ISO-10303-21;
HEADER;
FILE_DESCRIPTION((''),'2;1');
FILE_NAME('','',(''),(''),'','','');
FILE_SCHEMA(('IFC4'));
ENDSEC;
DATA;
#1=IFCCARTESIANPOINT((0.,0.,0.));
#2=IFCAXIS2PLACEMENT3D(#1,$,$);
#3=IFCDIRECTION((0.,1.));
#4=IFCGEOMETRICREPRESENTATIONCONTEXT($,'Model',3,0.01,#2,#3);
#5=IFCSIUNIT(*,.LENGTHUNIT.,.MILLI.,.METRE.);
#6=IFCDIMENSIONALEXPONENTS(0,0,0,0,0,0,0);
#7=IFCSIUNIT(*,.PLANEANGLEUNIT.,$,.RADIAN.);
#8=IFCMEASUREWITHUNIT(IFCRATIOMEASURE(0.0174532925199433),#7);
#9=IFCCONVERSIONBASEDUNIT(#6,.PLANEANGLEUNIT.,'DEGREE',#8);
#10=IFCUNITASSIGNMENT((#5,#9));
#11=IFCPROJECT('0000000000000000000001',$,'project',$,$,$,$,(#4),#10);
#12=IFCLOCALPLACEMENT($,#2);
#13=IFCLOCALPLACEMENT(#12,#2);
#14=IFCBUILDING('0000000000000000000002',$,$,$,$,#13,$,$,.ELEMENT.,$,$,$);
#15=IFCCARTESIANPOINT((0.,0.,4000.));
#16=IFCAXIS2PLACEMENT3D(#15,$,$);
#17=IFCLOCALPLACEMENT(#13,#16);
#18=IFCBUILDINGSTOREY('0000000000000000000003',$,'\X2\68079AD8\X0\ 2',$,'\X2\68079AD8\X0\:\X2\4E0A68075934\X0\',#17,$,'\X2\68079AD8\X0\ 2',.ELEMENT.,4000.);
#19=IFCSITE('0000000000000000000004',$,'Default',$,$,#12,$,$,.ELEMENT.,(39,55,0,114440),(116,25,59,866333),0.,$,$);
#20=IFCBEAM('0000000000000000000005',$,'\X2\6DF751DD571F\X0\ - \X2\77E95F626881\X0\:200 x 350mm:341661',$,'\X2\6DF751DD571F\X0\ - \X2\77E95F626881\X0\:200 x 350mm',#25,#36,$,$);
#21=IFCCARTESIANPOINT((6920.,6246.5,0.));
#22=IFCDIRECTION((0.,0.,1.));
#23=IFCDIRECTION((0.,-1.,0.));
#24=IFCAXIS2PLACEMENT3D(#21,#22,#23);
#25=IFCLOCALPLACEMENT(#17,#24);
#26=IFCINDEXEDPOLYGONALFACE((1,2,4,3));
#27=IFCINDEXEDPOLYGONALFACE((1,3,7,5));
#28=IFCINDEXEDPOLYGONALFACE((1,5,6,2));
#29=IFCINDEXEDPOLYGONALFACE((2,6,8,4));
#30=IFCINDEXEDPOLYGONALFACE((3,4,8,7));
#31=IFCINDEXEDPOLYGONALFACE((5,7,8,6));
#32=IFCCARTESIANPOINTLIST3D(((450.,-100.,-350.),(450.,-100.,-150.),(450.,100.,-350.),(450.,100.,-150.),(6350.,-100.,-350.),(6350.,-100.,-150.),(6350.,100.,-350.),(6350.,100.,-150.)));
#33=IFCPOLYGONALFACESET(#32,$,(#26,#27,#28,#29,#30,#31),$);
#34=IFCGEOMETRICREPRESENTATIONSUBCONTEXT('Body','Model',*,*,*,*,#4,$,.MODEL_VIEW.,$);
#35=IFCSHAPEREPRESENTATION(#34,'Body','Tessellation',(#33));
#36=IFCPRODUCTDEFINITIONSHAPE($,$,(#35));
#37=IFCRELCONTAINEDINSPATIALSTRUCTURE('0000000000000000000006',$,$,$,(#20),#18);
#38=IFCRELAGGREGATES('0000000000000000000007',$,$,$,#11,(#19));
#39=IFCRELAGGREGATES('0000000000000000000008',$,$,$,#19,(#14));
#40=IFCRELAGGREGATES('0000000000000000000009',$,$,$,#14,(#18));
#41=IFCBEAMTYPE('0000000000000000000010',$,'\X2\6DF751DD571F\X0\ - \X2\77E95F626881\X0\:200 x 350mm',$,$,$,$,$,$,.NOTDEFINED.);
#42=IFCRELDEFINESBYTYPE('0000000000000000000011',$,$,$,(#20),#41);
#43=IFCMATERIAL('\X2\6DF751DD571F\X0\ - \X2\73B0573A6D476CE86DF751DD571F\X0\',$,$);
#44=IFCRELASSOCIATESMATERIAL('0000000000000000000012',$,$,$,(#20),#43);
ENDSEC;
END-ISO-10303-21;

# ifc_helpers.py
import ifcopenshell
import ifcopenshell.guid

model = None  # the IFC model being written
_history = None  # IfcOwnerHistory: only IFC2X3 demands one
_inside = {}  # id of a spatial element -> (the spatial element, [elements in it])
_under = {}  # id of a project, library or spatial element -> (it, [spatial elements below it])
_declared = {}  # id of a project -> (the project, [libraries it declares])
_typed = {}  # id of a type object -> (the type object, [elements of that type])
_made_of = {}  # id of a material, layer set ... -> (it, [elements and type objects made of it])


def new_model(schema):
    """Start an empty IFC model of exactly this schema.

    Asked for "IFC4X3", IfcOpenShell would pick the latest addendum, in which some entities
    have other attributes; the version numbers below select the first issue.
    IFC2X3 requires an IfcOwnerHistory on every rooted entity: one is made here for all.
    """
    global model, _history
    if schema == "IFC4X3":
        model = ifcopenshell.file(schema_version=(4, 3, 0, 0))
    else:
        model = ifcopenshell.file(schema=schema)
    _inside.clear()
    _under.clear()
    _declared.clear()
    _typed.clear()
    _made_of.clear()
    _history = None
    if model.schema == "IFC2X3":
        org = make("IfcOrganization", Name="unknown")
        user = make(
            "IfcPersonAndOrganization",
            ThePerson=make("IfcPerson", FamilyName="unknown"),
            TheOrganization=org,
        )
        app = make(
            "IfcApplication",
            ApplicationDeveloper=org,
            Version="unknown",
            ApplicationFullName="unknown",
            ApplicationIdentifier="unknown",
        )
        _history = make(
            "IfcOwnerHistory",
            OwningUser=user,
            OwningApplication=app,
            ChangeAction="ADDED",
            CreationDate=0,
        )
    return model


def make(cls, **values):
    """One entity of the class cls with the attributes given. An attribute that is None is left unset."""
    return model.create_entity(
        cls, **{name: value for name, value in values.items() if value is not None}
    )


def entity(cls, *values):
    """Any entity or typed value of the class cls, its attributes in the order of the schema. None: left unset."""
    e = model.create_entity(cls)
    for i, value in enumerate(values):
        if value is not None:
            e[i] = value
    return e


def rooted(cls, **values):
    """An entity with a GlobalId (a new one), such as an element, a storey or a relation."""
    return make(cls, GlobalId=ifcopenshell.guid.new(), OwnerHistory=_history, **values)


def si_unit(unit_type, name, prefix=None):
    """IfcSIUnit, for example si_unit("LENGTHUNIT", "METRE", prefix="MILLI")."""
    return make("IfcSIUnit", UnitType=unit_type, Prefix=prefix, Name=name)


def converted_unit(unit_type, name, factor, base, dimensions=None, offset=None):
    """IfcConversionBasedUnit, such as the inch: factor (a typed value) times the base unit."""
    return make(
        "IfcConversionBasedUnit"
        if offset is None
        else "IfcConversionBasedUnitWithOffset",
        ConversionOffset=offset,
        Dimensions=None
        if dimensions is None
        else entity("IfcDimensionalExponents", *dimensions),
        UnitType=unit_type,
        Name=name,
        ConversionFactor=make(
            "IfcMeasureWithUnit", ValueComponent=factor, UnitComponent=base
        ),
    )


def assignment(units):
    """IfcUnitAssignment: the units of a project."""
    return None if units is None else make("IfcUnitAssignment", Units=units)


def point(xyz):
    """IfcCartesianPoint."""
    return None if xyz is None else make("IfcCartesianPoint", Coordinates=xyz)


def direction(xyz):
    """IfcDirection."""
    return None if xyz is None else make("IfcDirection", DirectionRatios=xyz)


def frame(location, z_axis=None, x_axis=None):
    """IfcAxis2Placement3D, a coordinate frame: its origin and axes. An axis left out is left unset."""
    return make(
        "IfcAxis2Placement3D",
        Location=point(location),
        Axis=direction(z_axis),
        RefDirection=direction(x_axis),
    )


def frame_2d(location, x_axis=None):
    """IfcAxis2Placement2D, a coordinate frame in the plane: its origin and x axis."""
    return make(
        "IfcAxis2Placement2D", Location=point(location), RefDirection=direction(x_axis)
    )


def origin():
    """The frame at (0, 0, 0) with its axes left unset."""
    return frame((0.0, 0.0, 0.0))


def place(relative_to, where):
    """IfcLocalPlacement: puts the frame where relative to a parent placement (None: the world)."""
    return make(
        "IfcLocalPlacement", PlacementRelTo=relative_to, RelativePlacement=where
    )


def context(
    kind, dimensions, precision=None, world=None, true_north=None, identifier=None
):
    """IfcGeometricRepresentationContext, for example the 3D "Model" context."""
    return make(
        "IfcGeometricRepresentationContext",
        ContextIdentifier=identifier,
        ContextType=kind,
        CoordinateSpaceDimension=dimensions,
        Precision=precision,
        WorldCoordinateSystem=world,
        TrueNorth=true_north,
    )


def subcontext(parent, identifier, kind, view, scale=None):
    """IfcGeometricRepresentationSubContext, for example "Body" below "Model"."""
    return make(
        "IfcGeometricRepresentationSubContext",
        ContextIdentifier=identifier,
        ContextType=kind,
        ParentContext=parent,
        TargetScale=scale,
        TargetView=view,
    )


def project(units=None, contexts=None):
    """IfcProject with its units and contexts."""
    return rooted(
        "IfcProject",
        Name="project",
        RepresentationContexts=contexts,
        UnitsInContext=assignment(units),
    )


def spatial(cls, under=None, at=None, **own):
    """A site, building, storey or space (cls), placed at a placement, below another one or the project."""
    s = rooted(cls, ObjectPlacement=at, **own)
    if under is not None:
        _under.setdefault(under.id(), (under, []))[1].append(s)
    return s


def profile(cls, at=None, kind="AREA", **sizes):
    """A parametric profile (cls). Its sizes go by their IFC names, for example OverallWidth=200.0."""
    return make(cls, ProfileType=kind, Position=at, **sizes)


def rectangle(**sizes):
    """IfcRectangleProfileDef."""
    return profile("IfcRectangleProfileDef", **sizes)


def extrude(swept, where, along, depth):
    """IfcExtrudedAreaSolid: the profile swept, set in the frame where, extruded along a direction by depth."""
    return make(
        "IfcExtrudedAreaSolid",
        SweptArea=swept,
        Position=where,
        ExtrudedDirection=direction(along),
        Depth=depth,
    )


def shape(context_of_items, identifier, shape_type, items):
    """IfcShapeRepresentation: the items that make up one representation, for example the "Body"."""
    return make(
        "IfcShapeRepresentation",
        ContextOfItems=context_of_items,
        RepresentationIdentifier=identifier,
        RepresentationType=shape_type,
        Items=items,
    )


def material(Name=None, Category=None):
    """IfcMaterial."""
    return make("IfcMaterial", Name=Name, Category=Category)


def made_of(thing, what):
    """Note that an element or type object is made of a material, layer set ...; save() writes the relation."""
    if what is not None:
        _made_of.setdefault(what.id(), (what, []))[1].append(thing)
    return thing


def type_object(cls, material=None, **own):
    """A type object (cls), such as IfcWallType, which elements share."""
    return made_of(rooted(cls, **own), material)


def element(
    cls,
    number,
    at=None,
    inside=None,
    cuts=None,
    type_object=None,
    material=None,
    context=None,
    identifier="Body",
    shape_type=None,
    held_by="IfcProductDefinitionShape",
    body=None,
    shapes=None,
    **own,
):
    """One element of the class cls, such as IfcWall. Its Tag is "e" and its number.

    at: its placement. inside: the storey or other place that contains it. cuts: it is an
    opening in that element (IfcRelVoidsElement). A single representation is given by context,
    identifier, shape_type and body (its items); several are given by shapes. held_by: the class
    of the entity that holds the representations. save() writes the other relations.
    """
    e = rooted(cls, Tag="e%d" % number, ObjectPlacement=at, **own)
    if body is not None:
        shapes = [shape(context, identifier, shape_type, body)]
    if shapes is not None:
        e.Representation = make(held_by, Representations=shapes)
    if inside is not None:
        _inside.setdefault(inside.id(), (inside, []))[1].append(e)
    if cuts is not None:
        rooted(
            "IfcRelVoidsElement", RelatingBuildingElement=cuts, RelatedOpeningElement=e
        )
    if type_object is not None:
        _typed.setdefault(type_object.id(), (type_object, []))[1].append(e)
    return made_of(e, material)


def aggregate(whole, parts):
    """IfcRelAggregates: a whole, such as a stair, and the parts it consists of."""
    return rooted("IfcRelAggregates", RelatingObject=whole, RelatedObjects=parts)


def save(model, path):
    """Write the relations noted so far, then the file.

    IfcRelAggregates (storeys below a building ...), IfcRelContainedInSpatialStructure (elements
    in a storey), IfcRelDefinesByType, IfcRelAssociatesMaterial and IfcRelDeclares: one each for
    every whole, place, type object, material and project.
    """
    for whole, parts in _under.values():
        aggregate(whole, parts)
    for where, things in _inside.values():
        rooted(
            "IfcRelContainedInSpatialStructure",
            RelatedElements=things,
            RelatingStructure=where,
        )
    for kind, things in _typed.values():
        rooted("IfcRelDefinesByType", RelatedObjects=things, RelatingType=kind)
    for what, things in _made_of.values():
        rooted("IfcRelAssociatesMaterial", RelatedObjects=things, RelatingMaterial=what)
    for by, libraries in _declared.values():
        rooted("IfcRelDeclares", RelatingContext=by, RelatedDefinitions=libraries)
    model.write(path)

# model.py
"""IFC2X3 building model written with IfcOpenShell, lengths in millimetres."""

from ifc_helpers import new_model, entity, si_unit, converted_unit, direction, frame, frame_2d, origin, place, context, subcontext, project, spatial, rectangle, extrude, material, type_object, element, save


model = new_model("IFC2X3")

# Units and contexts
model_context = context("Model", 3, precision=0.01, world=origin(), true_north=direction((0.0, 1.0)))
body_context = subcontext(model_context, "Body", "Model", "MODEL_VIEW")
ifc_project = project(units=[si_unit("LENGTHUNIT", "METRE", prefix="MILLI"), converted_unit("PLANEANGLEUNIT", "DEGREE", entity("IfcRatioMeasure", 0.0174532925199433), si_unit("PLANEANGLEUNIT", "RADIAN"), dimensions=[0, 0, 0, 0, 0, 0, 0])], contexts=[model_context])

# Site, building, storey
site_placement = place(None, origin())
site = spatial("IfcSite", under=ifc_project, at=site_placement, Name="Default", CompositionType="ELEMENT", RefLatitude=(39, 55, 0, 114440), RefLongitude=(116, 25, 59, 866333), RefElevation=0.0)
building_placement = place(site_placement, origin())
building = spatial("IfcBuilding", under=site, at=building_placement, CompositionType="ELEMENT")
storey_placement = place(building_placement, frame((0.0, 0.0, 4000.0)))
storey = spatial("IfcBuildingStorey", under=building, at=storey_placement, Name="标高 2", ObjectType="标高:上标头", LongName="标高 2", CompositionType="ELEMENT", Elevation=4000.0)

# Beam
ifc_material_1 = material(Name="混凝土 - 现场浇注混凝土")
beam_type_1 = type_object("IfcBeamType", Name="混凝土 - 矩形梁:200 x 350mm", PredefinedType="NOTDEFINED")
beam_1_placement = place(storey_placement, frame((6920.0, 6246.5, 0.0), z_axis=(0.0, 0.0, 1.0), x_axis=(0.0, -1.0, 0.0)))
element("IfcBeam", 1, at=beam_1_placement, inside=storey, type_object=beam_type_1, material=ifc_material_1, Name="混凝土 - 矩形梁:200 x 350mm:341661", ObjectType="混凝土 - 矩形梁:200 x 350mm", context=body_context, shape_type="SweptSolid", body=[
    extrude(rectangle(XDim=200.0, YDim=200.0, at=frame_2d((0.0, 0.0), x_axis=(1.0, 0.0))), frame((450.0, 0.0, -250.0), z_axis=(1.0, 0.0, 0.0), x_axis=(0.0, 0.0, -1.0)), (0.0, 0.0, 1.0), 5900.0),
])

save(model, "model.ifc")
